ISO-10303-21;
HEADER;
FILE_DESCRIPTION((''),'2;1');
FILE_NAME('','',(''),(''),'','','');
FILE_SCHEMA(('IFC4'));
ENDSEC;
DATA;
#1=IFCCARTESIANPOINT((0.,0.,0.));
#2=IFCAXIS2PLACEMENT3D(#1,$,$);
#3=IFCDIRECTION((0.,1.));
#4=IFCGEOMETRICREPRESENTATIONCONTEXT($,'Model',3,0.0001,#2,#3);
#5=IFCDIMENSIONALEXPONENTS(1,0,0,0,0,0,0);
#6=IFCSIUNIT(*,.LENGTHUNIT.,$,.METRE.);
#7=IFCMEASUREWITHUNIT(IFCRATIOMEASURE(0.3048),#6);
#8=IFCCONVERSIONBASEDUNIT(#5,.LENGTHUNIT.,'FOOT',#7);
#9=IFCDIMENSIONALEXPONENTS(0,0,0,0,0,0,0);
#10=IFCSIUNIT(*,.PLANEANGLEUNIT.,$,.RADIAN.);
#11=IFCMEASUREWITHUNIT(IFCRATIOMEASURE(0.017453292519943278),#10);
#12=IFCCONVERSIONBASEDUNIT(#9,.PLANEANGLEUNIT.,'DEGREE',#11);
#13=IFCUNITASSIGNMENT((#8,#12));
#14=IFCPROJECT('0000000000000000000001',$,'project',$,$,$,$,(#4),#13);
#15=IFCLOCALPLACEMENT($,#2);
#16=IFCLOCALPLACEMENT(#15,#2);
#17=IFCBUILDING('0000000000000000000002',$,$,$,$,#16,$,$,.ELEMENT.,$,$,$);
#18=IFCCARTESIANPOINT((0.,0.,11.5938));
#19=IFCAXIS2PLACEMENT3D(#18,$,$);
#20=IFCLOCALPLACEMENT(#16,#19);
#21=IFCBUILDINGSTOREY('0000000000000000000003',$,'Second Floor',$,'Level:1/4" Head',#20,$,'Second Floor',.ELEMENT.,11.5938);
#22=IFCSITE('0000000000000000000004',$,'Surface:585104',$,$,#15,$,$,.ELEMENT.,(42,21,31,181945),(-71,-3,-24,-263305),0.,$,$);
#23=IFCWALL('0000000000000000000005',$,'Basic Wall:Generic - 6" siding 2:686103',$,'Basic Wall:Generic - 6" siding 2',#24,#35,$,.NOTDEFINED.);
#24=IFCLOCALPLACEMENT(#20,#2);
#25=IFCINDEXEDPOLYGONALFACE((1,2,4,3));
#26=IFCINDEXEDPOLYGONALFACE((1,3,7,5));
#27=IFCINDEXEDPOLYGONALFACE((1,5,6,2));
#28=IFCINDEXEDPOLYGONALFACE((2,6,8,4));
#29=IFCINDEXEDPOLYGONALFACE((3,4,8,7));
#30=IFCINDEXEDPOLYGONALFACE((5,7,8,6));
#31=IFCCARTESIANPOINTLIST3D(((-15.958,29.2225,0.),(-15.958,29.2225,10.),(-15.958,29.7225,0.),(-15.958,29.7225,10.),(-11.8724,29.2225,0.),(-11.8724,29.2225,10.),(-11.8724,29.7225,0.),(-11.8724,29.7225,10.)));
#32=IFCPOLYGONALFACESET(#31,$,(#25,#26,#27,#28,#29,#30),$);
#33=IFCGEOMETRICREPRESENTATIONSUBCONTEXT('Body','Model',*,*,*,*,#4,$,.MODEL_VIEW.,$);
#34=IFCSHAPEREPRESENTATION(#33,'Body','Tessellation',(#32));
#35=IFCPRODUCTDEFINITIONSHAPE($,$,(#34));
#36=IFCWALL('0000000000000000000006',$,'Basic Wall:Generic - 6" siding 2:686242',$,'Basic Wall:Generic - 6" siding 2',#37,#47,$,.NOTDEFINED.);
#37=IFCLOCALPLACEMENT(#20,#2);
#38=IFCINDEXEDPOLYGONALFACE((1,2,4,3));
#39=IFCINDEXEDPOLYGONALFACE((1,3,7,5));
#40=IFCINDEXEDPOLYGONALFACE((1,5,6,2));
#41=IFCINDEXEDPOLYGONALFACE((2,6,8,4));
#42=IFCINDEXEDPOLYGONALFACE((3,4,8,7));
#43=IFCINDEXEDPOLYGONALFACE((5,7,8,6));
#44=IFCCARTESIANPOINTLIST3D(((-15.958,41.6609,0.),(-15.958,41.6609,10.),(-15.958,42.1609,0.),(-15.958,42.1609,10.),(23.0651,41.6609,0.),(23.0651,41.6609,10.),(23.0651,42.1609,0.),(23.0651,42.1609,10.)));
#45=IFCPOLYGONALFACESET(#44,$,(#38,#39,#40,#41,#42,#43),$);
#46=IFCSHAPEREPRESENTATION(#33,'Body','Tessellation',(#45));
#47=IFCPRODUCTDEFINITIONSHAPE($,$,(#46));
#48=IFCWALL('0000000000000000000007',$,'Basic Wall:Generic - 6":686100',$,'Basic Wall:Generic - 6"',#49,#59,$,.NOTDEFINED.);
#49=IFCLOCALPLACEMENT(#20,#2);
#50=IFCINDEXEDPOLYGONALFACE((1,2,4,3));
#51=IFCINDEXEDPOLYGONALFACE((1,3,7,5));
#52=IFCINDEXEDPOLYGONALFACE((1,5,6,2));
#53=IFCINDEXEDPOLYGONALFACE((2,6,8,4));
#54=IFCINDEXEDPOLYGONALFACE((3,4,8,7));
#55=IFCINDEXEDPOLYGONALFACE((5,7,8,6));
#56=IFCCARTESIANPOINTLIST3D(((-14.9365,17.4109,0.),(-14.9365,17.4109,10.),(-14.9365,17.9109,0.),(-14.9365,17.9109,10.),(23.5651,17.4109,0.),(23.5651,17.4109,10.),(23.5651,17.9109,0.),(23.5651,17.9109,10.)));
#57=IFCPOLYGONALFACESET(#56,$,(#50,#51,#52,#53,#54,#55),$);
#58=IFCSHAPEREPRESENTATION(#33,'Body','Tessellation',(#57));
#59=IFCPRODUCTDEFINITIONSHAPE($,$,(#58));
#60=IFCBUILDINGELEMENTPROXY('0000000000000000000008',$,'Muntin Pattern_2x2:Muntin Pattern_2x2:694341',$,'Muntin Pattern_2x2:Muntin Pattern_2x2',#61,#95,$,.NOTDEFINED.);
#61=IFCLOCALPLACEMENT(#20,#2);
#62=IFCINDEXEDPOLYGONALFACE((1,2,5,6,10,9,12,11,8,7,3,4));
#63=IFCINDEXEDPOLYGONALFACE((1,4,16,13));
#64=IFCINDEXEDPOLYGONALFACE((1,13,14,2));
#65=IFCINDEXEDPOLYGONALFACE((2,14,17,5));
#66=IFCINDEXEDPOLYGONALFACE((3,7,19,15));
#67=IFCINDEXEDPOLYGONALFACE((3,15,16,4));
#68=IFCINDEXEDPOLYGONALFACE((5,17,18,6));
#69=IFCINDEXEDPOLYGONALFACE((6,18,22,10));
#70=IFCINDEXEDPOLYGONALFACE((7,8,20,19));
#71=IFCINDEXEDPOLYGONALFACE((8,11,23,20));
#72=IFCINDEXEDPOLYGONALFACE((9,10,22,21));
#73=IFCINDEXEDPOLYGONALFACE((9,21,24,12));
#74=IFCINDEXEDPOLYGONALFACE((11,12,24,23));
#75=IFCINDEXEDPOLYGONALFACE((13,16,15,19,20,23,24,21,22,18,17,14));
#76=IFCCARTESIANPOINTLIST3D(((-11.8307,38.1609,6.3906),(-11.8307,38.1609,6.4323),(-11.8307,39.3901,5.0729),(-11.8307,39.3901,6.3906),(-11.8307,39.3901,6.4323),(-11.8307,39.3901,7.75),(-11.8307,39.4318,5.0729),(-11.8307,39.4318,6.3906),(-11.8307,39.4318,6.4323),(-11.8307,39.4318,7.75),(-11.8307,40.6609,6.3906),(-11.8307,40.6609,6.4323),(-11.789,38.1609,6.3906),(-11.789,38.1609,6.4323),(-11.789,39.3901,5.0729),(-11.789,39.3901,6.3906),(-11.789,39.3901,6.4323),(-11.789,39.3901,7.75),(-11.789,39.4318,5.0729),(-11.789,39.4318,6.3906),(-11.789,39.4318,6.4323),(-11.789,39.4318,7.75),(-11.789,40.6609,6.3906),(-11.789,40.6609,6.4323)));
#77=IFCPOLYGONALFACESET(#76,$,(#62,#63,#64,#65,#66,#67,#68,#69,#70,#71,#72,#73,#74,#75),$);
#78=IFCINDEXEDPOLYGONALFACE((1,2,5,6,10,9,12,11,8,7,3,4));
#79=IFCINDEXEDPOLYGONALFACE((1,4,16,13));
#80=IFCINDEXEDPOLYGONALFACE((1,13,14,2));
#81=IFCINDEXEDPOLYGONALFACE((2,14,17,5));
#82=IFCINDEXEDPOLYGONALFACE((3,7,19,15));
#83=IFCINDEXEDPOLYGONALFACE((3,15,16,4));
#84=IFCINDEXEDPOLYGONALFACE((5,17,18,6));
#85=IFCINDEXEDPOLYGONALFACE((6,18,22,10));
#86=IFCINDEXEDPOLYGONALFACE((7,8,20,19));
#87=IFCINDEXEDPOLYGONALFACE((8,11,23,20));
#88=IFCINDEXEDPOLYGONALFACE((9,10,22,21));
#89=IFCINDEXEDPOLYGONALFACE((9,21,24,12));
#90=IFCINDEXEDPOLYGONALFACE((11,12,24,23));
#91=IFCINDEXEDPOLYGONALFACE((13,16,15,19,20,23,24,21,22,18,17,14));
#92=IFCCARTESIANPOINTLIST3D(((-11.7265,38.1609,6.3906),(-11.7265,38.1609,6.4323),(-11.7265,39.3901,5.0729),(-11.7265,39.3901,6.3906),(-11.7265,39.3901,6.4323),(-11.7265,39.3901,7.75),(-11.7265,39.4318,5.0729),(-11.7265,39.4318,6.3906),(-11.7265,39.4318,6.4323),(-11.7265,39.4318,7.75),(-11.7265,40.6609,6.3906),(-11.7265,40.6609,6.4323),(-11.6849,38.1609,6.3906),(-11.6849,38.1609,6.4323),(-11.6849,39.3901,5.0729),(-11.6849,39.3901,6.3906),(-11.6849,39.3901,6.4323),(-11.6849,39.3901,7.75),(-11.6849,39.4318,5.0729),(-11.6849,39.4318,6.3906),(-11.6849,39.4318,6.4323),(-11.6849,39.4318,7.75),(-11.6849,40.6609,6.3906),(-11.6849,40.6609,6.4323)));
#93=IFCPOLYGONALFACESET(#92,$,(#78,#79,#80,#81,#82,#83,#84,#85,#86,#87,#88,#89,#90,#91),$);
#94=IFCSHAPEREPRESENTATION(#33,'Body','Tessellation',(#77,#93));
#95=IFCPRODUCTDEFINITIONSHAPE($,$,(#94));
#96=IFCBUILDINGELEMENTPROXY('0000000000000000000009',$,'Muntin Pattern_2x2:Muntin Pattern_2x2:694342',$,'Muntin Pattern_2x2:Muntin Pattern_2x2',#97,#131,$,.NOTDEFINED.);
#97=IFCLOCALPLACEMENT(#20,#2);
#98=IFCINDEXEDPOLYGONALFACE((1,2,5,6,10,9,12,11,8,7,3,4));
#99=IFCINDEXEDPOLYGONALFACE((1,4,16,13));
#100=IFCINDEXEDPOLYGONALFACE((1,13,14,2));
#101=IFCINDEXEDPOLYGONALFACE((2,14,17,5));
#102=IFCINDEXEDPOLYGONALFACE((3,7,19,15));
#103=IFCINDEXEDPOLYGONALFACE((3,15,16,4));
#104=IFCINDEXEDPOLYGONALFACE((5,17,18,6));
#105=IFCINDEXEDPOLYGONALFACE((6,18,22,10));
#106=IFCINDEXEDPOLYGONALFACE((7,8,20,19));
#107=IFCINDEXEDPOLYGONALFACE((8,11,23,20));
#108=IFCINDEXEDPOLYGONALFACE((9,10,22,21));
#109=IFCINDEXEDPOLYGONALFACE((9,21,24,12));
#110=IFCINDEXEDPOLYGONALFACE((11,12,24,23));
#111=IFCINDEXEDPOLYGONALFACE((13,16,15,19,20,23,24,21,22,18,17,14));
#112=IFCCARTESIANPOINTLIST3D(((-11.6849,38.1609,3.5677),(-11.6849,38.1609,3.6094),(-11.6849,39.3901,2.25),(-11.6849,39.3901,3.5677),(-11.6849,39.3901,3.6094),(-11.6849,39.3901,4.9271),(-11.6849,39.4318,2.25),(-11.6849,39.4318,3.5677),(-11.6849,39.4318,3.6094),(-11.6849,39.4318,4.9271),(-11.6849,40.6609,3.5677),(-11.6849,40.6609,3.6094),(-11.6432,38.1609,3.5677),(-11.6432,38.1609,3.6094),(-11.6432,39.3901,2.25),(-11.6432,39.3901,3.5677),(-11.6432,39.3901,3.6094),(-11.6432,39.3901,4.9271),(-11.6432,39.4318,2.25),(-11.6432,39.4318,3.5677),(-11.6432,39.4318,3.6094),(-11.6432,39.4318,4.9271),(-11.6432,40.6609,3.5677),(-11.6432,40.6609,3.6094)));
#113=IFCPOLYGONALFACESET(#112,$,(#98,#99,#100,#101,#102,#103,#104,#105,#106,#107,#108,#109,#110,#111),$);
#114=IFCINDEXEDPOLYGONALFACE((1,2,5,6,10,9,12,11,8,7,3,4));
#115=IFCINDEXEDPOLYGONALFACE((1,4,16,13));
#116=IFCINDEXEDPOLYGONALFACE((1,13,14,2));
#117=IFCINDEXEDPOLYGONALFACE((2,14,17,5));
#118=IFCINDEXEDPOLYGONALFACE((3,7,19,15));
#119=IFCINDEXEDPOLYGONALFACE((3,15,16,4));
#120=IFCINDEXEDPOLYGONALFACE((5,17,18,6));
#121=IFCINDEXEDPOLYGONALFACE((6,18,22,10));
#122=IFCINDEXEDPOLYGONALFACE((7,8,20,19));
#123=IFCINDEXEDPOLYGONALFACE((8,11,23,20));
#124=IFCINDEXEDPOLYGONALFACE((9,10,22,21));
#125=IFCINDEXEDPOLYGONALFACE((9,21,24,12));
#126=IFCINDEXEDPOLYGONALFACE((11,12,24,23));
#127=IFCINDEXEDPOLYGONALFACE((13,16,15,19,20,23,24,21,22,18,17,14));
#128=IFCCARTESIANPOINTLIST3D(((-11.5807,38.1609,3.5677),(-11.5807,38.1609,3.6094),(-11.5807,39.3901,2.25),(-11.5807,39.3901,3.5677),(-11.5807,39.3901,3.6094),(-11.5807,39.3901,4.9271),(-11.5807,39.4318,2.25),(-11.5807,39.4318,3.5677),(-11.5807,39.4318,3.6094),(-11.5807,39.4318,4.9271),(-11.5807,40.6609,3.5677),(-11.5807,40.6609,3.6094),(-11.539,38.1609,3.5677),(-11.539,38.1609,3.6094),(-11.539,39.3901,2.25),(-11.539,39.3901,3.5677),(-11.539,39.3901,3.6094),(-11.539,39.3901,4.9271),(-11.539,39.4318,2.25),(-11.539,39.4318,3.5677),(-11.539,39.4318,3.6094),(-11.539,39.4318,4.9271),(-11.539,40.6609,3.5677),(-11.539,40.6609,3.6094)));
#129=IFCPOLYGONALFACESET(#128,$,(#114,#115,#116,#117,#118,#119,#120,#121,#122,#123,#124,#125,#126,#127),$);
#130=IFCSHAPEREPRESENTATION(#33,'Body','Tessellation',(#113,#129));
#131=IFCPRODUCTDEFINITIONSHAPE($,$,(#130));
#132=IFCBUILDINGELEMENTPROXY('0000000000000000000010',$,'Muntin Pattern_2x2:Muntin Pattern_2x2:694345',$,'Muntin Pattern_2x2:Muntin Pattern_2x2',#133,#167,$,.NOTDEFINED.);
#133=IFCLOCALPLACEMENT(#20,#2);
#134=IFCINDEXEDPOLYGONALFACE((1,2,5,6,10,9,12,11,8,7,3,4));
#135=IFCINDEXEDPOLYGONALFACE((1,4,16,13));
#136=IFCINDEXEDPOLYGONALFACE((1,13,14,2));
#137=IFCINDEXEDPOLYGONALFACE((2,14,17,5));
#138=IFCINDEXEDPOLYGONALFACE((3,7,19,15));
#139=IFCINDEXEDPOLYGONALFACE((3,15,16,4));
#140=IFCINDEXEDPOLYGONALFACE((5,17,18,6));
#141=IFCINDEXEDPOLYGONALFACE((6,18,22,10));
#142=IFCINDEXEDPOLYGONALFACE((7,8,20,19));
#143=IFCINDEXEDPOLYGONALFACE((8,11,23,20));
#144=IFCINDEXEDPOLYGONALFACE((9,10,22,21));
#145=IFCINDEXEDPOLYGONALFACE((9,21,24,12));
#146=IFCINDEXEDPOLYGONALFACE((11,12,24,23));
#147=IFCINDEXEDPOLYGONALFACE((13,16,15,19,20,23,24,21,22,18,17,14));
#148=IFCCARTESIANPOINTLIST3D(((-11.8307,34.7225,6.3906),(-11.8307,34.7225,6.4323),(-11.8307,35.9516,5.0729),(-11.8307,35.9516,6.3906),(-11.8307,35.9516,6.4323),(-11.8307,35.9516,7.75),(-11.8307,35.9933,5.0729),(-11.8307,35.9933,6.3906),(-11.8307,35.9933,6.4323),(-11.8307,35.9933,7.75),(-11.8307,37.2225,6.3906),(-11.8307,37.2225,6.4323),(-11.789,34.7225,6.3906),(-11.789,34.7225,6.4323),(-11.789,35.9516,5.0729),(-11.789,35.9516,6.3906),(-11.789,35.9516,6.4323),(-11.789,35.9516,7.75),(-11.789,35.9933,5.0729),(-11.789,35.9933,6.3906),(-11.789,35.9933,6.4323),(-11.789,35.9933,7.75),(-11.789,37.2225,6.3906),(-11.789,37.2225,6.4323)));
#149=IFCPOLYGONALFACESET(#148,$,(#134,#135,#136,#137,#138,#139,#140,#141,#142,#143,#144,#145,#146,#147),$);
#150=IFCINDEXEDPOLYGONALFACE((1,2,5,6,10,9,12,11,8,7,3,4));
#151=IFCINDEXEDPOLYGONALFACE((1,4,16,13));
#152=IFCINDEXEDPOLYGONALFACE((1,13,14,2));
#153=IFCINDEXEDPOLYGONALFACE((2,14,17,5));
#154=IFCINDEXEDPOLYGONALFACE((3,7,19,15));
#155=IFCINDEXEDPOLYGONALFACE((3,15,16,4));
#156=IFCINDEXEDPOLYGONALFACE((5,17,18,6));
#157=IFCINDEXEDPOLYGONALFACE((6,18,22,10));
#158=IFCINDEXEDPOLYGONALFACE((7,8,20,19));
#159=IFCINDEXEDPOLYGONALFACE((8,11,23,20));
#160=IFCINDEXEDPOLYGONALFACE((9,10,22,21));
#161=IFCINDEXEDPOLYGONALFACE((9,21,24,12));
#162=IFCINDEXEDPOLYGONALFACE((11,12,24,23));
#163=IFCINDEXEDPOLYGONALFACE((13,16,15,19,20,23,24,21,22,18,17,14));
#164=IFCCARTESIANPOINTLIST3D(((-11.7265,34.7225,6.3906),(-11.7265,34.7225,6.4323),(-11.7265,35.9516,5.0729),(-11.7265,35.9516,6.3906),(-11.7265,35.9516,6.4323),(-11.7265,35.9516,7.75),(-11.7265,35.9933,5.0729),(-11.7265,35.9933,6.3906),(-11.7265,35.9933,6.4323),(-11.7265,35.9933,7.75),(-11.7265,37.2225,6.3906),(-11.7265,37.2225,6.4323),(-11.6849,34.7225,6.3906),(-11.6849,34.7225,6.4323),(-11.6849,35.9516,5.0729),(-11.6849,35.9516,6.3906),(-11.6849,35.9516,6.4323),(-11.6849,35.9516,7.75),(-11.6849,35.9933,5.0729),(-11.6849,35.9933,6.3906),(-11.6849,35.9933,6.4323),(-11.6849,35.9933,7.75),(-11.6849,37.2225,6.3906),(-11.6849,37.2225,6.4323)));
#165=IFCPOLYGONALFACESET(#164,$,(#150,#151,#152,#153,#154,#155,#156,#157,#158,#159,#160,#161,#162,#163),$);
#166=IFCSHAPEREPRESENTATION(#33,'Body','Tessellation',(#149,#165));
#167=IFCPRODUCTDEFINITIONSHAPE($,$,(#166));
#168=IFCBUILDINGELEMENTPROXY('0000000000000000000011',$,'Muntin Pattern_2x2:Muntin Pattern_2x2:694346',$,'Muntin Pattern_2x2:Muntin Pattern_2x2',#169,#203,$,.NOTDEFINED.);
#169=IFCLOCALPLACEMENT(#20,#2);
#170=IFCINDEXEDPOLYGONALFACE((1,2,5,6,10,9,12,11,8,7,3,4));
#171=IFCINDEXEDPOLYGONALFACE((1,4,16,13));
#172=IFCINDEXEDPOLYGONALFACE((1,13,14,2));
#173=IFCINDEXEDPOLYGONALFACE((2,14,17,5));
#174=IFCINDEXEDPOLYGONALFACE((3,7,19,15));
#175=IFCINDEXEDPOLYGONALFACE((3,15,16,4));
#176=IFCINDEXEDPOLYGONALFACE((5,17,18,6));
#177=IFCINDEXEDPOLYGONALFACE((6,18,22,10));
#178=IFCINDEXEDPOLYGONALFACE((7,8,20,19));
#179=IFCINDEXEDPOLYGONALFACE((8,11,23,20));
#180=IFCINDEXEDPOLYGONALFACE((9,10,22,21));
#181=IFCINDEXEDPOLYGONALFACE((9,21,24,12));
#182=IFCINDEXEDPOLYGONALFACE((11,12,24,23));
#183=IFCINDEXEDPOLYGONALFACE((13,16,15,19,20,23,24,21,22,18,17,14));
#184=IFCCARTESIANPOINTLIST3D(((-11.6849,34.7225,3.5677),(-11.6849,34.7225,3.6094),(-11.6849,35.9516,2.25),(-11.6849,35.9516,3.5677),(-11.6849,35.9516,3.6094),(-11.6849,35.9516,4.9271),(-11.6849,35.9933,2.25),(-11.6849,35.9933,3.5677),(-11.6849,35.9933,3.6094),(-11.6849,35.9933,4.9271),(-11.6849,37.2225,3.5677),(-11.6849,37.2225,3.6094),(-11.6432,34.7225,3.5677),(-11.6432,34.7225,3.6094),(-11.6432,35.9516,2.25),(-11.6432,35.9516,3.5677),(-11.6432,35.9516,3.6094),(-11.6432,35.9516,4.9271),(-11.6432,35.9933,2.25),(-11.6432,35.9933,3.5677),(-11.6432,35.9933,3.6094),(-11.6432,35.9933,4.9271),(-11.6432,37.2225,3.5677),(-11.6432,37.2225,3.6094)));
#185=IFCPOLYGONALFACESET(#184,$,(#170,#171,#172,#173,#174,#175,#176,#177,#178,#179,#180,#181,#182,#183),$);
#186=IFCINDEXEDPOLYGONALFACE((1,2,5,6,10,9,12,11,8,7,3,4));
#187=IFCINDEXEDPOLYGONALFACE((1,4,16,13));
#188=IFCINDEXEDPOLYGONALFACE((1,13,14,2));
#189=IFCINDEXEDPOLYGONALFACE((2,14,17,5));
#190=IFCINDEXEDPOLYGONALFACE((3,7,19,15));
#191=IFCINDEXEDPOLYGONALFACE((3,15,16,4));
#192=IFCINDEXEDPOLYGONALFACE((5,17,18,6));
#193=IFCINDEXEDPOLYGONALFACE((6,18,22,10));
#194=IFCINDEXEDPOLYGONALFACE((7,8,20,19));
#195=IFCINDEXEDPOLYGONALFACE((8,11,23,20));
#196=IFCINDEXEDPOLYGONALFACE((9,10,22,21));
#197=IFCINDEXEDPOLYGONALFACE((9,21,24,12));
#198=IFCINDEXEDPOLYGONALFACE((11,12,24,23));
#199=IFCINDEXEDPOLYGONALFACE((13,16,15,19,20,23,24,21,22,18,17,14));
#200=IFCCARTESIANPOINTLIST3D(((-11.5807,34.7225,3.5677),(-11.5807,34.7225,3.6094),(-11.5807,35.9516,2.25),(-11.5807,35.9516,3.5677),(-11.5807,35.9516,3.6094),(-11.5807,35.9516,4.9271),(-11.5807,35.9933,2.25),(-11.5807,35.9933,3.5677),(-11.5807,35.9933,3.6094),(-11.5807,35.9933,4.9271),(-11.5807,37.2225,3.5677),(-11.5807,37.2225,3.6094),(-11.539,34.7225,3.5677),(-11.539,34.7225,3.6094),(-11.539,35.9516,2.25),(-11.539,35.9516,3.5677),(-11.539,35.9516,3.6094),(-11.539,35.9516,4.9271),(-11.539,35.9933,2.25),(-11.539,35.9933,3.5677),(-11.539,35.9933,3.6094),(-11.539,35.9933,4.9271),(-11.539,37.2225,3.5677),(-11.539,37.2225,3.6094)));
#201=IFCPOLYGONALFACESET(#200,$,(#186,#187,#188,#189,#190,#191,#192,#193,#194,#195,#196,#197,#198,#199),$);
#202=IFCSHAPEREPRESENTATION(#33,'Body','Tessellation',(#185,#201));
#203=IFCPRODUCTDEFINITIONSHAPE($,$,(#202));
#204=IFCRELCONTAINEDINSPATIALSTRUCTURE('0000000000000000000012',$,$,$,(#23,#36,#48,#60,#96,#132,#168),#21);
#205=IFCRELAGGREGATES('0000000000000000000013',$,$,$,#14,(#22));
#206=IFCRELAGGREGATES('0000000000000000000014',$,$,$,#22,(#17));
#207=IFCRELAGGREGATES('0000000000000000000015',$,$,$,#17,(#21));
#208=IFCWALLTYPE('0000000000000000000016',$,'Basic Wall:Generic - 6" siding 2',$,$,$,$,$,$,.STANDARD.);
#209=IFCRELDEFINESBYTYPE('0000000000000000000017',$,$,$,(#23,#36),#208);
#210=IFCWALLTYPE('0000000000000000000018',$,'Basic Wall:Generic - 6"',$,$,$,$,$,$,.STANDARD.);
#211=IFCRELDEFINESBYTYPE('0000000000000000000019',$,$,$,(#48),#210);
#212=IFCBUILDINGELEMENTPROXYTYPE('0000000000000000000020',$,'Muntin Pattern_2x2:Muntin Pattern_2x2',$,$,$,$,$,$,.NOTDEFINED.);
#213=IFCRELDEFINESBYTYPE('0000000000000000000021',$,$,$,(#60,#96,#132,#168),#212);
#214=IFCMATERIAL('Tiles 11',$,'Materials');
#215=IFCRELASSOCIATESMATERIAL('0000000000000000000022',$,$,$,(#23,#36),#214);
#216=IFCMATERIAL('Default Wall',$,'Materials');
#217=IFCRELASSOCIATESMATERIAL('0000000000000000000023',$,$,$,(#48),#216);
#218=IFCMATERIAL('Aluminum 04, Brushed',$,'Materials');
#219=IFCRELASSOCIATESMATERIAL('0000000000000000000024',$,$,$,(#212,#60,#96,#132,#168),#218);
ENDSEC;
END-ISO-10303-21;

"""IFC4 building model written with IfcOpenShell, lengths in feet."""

from ifc_helpers import new_model, entity, si_unit, converted_unit, direction, frame, origin, place, context, subcontext, project, spatial, indexed_curve, outline, extrude, source, transform, mapped, material, type_object, type_shapes, element, save


model = new_model("IFC4")

# Units and contexts
model_context = context("Model", 3, precision=0.0001, world=origin(), true_north=direction((0.0, 1.0)))
body_context = subcontext(model_context, "Body", "Model", "MODEL_VIEW")
ifc_project = project(units=[converted_unit("LENGTHUNIT", "FOOT", entity("IfcRatioMeasure", 0.3048), si_unit("LENGTHUNIT", "METRE"), dimensions=[1, 0, 0, 0, 0, 0, 0]), converted_unit("PLANEANGLEUNIT", "DEGREE", entity("IfcRatioMeasure", 0.017453292519943278), si_unit("PLANEANGLEUNIT", "RADIAN"), dimensions=[0, 0, 0, 0, 0, 0, 0])], contexts=[model_context])

# Site, building, storey
site_placement = place(None, origin())
site = spatial("IfcSite", under=ifc_project, at=site_placement, Name="Surface:585104", CompositionType="ELEMENT", RefLatitude=(42, 21, 31, 181945), RefLongitude=(-71, -3, -24, -263305), RefElevation=0.0)
building_placement = place(site_placement, origin())
building = spatial("IfcBuilding", under=site, at=building_placement, CompositionType="ELEMENT")
storey_placement = place(building_placement, frame((0.0, 0.0, 11.5938)))
storey = spatial("IfcBuildingStorey", under=building, at=storey_placement, Name="Second Floor", ObjectType="Level:1/4\" Head", LongName="Second Floor", CompositionType="ELEMENT", Elevation=11.5938)

# Walls
ifc_material_1 = material(Name="Tiles 11", Category="Materials")
wall_type_1 = type_object("IfcWallType", Name="Basic Wall:Generic - 6\" siding 2", PredefinedType="STANDARD")
wall_1_placement = place(storey_placement, frame((-11.3727, 29.4725, 0.0), z_axis=(0.0, 0.0, 1.0), x_axis=(-1.0, 0.0, 0.0)))
element("IfcWall", 1, at=wall_1_placement, inside=storey, type_object=wall_type_1, material=ifc_material_1, Name="Basic Wall:Generic - 6\" siding 2:686103", ObjectType="Basic Wall:Generic - 6\" siding 2", PredefinedType="NOTDEFINED", context=body_context, shape_type="SweptSolid", body=[
    extrude(outline(indexed_curve([(-0.25, -2.0428), (0.25, -2.0428), (0.25, 2.0428), (-0.25, 2.0428), (-0.25, -2.0428)], self_intersect=False)), frame((2.5424, 0.0, 0.0), z_axis=(0.0, 0.0, 1.0), x_axis=(0.0, 1.0, 0.0)), (0.0, 0.0, 1.0), 10.0),
])
wall_2_placement = place(storey_placement, frame((-15.958, 41.9109, 0.0)))
element("IfcWall", 2, at=wall_2_placement, inside=storey, type_object=wall_type_1, material=ifc_material_1, Name="Basic Wall:Generic - 6\" siding 2:686242", ObjectType="Basic Wall:Generic - 6\" siding 2", PredefinedType="NOTDEFINED", context=body_context, shape_type="SweptSolid", body=[
    extrude(outline(indexed_curve([(-0.25, -19.5115), (0.25, -19.5115), (0.25, 19.5115), (-0.25, 19.5115), (-0.25, -19.5115)], self_intersect=False)), frame((19.5115, 0.0, 0.0), z_axis=(0.0, 0.0, 1.0), x_axis=(0.0, 1.0, 0.0)), (0.0, 0.0, 1.0), 10.0),
])
ifc_material_2 = material(Name="Default Wall", Category="Materials")
wall_type_2 = type_object("IfcWallType", Name="Basic Wall:Generic - 6\"", PredefinedType="STANDARD")
wall_3_placement = place(storey_placement, frame((-14.9365, 17.6609, 0.0)))
element("IfcWall", 3, at=wall_3_placement, inside=storey, type_object=wall_type_2, material=ifc_material_2, Name="Basic Wall:Generic - 6\":686100", ObjectType="Basic Wall:Generic - 6\"", PredefinedType="NOTDEFINED", context=body_context, shape_type="SweptSolid", body=[
    extrude(outline(indexed_curve([(-0.25, -19.2508), (0.25, -19.2508), (0.25, 19.2508), (-0.25, 19.2508), (-0.25, -19.2508)], self_intersect=False)), frame((19.2508, 0.0, 0.0), z_axis=(0.0, 0.0, 1.0), x_axis=(0.0, 1.0, 0.0)), (0.0, 0.0, 1.0), 10.0),
])

# Building element proxies
ifc_material_3 = material(Name="Aluminum 04, Brushed", Category="Materials")
building_element_proxy_type_1 = type_object("IfcBuildingElementProxyType", Name="Muntin Pattern_2x2:Muntin Pattern_2x2", PredefinedType="NOTDEFINED", material=ifc_material_3)
shared_shape_1 = source(origin(), body_context, "Body", "SweptSolid", [
    extrude(outline(indexed_curve([(0.0208, -0.0208), (1.3385, -0.0208), (1.3385, 0.0208), (0.0208, 0.0208), (0.0208, 1.25), (-0.0208, 1.25), (-0.0208, 0.0208), (-1.3385, 0.0208), (-1.3385, -0.0208), (-0.0208, -0.0208), (-0.0208, -1.25), (0.0208, -1.25), (0.0208, -0.0208)], self_intersect=False)), frame((0.0, -0.0729, 1.3385), z_axis=(0.0, 1.0, 0.0), x_axis=(0.0, 0.0, 1.0)), (0.0, 0.0, 1.0), 0.0417),
    extrude(outline(indexed_curve([(0.0208, -0.0208), (1.3385, -0.0208), (1.3385, 0.0208), (0.0208, 0.0208), (0.0208, 1.25), (-0.0208, 1.25), (-0.0208, 0.0208), (-1.3385, 0.0208), (-1.3385, -0.0208), (-0.0208, -0.0208), (-0.0208, -1.25), (0.0208, -1.25), (0.0208, -0.0208)], self_intersect=False)), frame((0.0, 0.0313, 1.3385), z_axis=(0.0, 1.0, 0.0), x_axis=(0.0, 0.0, 1.0)), (0.0, 0.0, 1.0), 0.0417),
])
type_shapes(building_element_proxy_type_1, [shared_shape_1])
for number, where, z_axis, x_axis, name in (
    (4, (-11.7578, 39.4109, 5.0729), (0.0, 0.0, 1.0), (0.0, -1.0, 0.0), "Muntin Pattern_2x2:Muntin Pattern_2x2:694341"),
    (5, (-11.612, 39.4109, 2.25), (0.0, 0.0, 1.0), (0.0, -1.0, 0.0), "Muntin Pattern_2x2:Muntin Pattern_2x2:694342"),
    (6, (-11.7578, 35.9725, 5.0729), (0.0, 0.0, 1.0), (0.0, -1.0, 0.0), "Muntin Pattern_2x2:Muntin Pattern_2x2:694345"),
    (7, (-11.612, 35.9725, 2.25), (0.0, 0.0, 1.0), (0.0, -1.0, 0.0), "Muntin Pattern_2x2:Muntin Pattern_2x2:694346"),
):
    element("IfcBuildingElementProxy", number, at=place(storey_placement, frame(where, z_axis=z_axis, x_axis=x_axis)), inside=storey, type_object=building_element_proxy_type_1, material=ifc_material_3, Name=name, ObjectType="Muntin Pattern_2x2:Muntin Pattern_2x2", PredefinedType="NOTDEFINED", context=body_context, shape_type="MappedRepresentation", body=[
        mapped(shared_shape_1, transform((0.0, 0.0, 0.0), scale=1.0)),
    ])

save(model, "model.ifc")
